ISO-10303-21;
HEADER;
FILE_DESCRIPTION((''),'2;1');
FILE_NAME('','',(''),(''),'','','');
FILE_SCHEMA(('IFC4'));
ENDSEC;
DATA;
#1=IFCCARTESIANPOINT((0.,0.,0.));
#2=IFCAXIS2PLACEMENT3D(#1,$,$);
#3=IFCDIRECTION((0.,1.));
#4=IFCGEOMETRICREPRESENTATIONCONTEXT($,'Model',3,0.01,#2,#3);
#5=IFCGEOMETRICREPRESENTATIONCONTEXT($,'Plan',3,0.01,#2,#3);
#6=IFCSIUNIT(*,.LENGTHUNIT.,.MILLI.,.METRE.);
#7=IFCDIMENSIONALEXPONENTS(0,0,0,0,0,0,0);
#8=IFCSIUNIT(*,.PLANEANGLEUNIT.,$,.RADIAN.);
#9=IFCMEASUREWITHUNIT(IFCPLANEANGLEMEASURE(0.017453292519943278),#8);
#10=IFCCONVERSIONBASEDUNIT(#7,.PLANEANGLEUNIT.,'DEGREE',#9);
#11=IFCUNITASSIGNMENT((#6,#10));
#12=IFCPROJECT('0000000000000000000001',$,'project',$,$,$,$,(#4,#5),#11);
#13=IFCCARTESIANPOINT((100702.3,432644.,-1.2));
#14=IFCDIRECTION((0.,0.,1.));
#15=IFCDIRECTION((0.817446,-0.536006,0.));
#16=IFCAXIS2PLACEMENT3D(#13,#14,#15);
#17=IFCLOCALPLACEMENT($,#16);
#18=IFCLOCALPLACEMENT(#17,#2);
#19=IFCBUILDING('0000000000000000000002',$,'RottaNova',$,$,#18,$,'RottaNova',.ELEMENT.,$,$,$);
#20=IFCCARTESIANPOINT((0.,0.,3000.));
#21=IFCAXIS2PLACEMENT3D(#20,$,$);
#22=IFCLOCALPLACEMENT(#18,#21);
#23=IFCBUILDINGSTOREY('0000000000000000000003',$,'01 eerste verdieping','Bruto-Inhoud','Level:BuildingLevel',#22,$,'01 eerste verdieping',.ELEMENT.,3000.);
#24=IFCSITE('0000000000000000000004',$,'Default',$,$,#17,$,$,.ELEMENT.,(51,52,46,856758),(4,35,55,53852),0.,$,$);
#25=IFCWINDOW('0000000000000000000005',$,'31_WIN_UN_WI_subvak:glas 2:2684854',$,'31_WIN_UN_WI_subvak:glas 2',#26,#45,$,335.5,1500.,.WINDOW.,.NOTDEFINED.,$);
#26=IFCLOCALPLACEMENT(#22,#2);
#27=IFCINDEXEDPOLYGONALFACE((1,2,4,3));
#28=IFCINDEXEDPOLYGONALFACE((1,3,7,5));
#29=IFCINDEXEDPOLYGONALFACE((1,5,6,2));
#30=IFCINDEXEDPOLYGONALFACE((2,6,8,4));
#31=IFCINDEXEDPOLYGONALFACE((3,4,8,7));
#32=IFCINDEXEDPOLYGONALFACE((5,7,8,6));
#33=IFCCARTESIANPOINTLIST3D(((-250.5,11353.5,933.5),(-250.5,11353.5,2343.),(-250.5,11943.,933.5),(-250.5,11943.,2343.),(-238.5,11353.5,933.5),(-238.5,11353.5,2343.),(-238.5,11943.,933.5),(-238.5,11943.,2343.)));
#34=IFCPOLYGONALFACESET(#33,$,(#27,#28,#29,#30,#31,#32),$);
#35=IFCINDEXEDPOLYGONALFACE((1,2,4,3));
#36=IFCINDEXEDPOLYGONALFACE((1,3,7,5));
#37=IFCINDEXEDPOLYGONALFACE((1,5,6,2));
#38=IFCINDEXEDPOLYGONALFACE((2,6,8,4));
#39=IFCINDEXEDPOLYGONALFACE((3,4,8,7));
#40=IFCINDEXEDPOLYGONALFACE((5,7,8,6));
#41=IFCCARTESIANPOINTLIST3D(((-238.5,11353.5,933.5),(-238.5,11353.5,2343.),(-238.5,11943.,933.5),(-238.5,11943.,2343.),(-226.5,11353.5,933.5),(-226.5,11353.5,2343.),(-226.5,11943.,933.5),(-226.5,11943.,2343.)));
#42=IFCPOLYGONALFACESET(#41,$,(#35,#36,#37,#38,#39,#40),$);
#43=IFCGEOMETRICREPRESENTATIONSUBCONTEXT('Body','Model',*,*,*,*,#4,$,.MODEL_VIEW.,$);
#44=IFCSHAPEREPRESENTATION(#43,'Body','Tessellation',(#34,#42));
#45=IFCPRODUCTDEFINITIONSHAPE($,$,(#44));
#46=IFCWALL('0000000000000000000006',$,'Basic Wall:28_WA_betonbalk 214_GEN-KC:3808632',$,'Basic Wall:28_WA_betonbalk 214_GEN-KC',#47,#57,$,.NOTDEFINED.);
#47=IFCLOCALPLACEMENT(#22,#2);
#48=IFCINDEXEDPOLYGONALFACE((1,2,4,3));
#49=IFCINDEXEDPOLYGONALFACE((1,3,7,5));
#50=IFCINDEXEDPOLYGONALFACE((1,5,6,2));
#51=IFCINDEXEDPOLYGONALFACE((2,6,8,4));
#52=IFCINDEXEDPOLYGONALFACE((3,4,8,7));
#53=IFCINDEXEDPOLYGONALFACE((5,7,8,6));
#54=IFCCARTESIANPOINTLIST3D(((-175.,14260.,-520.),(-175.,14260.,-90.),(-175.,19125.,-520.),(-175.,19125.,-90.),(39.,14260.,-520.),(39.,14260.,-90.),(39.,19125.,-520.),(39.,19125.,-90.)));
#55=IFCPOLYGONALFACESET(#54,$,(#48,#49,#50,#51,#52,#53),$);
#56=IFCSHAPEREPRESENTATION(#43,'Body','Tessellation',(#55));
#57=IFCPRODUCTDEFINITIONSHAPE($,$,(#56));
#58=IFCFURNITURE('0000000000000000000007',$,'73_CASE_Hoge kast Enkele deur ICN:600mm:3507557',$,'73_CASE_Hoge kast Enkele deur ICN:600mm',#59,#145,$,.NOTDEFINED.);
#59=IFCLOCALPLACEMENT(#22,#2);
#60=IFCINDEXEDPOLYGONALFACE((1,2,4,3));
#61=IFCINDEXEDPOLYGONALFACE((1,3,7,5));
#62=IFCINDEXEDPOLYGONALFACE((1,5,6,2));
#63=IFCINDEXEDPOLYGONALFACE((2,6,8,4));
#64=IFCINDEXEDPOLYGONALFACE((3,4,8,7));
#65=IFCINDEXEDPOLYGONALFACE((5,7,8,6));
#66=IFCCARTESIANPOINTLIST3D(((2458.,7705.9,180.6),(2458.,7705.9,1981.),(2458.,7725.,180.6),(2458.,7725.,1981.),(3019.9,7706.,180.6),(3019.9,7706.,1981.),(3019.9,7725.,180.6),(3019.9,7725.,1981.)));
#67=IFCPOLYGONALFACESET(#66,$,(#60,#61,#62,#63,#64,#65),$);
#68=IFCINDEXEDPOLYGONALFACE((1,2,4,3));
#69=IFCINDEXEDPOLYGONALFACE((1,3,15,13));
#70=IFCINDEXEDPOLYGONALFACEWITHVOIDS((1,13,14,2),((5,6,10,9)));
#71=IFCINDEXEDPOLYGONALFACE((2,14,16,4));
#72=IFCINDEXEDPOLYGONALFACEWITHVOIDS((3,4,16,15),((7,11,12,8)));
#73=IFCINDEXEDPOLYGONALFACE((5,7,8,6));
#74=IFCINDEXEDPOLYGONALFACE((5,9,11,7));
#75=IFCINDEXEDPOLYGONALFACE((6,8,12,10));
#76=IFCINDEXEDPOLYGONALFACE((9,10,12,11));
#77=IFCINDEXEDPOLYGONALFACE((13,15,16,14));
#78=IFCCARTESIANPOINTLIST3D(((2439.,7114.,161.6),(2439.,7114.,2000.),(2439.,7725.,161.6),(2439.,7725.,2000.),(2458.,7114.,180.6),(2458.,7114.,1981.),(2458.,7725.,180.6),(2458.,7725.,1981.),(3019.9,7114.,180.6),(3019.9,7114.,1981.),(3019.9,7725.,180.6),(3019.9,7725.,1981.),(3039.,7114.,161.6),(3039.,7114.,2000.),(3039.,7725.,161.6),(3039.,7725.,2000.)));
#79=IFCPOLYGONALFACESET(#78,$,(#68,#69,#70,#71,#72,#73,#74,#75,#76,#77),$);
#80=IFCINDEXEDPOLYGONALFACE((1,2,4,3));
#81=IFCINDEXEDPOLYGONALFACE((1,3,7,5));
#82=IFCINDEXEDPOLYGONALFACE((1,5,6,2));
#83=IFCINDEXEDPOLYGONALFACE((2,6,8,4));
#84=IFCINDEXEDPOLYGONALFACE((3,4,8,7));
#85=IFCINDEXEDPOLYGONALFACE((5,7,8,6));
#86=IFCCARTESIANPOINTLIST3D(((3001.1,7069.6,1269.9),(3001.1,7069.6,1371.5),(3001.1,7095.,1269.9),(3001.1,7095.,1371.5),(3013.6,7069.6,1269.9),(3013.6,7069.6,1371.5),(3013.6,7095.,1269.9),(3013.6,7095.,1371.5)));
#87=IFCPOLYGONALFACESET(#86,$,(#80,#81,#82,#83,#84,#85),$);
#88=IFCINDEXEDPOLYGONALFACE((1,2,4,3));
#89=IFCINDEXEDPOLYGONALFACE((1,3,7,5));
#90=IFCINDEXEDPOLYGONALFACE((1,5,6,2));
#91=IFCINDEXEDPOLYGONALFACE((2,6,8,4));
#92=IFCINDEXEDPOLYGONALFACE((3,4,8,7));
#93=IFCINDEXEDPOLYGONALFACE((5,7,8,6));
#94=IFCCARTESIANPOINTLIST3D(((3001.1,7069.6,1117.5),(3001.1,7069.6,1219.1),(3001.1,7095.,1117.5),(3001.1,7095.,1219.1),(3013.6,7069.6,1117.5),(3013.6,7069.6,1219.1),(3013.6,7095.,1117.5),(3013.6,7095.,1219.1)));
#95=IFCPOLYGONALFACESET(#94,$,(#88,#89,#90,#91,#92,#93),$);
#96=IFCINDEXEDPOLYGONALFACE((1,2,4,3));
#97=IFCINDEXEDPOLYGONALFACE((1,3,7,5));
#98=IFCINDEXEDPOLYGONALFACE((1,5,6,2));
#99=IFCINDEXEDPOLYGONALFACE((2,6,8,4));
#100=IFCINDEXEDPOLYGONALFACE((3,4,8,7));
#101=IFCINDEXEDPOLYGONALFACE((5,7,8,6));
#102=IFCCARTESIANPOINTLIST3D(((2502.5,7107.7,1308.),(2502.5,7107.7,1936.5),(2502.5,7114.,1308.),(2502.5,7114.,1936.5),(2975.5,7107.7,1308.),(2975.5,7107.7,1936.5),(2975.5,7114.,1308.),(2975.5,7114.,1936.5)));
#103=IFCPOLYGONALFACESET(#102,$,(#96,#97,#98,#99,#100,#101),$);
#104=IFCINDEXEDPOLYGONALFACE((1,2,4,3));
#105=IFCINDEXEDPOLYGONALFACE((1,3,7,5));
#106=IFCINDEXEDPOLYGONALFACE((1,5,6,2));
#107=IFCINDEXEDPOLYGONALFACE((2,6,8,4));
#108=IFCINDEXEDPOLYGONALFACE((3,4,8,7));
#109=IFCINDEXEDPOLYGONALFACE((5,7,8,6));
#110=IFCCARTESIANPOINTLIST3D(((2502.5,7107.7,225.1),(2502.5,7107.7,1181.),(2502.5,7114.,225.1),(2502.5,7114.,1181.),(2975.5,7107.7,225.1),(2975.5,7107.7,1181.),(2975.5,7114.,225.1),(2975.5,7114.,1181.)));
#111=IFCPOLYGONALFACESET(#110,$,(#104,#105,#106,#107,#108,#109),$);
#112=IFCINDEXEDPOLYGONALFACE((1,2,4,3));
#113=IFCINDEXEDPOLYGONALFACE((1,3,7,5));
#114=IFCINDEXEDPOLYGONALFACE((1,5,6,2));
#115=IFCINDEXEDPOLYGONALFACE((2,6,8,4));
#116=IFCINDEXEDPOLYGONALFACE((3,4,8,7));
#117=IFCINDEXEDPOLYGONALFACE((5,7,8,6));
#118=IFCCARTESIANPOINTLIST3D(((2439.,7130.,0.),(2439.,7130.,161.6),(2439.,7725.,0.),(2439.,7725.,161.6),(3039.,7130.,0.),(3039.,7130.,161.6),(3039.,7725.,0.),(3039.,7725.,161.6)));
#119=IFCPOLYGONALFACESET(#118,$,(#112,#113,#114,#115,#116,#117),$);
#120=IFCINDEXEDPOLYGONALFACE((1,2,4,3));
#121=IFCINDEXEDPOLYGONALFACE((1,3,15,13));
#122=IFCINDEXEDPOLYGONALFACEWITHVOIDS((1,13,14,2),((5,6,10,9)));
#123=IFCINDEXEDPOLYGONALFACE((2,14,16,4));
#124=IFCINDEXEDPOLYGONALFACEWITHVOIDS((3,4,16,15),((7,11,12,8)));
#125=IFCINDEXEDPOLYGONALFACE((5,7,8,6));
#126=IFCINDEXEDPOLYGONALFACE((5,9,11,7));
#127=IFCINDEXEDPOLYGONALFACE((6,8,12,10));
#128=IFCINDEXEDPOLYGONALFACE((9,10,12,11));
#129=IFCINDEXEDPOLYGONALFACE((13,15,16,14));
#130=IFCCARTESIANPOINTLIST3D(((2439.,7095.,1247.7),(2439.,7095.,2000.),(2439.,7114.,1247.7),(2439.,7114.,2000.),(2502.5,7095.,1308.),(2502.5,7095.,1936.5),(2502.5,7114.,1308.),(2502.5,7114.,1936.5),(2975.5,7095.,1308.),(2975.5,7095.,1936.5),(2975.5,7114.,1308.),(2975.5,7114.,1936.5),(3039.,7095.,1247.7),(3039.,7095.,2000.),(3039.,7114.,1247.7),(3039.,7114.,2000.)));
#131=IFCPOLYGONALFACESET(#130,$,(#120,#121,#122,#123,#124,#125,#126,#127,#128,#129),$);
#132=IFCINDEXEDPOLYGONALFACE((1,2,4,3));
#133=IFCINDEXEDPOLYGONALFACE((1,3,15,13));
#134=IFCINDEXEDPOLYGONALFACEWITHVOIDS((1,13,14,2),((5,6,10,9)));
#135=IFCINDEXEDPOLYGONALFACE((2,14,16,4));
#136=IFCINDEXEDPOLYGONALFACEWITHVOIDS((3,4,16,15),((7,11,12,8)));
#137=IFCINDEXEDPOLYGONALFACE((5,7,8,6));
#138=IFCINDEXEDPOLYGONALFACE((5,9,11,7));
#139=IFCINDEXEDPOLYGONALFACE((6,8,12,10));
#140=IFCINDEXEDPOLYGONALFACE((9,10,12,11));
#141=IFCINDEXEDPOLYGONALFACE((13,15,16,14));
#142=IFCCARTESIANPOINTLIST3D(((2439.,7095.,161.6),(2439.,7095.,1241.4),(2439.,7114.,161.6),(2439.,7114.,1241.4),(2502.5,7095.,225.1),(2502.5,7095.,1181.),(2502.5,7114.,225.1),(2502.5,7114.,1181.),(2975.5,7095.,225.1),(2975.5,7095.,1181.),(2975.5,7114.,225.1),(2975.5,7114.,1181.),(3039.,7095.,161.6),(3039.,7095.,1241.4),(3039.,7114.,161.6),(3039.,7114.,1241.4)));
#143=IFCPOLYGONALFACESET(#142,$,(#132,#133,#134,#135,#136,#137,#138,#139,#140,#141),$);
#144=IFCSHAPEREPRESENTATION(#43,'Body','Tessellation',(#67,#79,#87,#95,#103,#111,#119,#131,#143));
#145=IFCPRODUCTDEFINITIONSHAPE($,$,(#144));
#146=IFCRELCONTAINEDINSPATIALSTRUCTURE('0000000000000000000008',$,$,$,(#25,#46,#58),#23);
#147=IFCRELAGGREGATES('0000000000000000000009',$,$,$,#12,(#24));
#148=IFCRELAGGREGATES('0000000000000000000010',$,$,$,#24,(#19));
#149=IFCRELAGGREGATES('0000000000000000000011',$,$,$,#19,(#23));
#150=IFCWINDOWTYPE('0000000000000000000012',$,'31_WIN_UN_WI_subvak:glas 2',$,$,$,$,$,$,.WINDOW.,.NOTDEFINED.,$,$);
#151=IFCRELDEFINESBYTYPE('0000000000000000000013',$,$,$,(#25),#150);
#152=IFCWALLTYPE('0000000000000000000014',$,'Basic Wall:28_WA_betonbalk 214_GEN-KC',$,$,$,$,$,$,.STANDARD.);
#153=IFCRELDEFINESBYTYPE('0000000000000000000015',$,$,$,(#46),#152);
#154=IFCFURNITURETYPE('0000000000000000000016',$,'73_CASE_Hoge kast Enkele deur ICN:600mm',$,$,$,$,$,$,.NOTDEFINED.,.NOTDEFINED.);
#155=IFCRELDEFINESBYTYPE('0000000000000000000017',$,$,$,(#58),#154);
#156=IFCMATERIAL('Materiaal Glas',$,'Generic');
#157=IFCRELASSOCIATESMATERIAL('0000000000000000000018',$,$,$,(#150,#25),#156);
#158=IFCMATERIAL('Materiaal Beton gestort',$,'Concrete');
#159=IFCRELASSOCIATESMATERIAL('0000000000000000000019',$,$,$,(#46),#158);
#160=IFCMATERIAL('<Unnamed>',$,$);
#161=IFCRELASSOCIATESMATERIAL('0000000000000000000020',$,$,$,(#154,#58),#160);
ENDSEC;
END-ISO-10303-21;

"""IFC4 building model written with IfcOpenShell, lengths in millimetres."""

from ifc_helpers import new_model, entity, si_unit, converted_unit, direction, frame, origin, place, context, subcontext, project, spatial, indexed_curve, outline, extrude, source, transform, mapped, material, type_object, type_shapes, element, save


model = new_model("IFC4")

# Units and contexts
model_context = context("Model", 3, precision=0.01, world=origin(), true_north=direction((0.0, 1.0)))
plan_context = context("Plan", 3, precision=0.01, world=origin(), true_north=direction((0.0, 1.0)))
body_context = subcontext(model_context, "Body", "Model", "MODEL_VIEW")
ifc_project = project(units=[si_unit("LENGTHUNIT", "METRE", prefix="MILLI"), converted_unit("PLANEANGLEUNIT", "DEGREE", entity("IfcPlaneAngleMeasure", 0.017453292519943278), si_unit("PLANEANGLEUNIT", "RADIAN"), dimensions=[0, 0, 0, 0, 0, 0, 0])], contexts=[model_context, plan_context])

# Site, building, storey
site_placement = place(None, frame((100702.3, 432644.0, -1.2), z_axis=(0.0, 0.0, 1.0), x_axis=(0.817446, -0.536006, 0.0)))
site = spatial("IfcSite", under=ifc_project, at=site_placement, Name="Default", CompositionType="ELEMENT", RefLatitude=(51, 52, 46, 856758), RefLongitude=(4, 35, 55, 53852), RefElevation=0.0)
building_placement = place(site_placement, origin())
building = spatial("IfcBuilding", under=site, at=building_placement, Name="RottaNova", LongName="RottaNova", CompositionType="ELEMENT")
storey_placement = place(building_placement, frame((0.0, 0.0, 3000.0)))
storey = spatial("IfcBuildingStorey", under=building, at=storey_placement, Name="01 eerste verdieping", Description="Bruto-Inhoud", ObjectType="Level:BuildingLevel", LongName="01 eerste verdieping", CompositionType="ELEMENT", Elevation=3000.0)

# Shared definitions
ifc_material_1 = material(Name="Materiaal Glas", Category="Generic")

# Window
window_type = type_object("IfcWindowType", Name="31_WIN_UN_WI_subvak:glas 2", PartitioningType="NOTDEFINED", PredefinedType="WINDOW", material=ifc_material_1)
shared_shape_1 = source(origin(), body_context, "Body", "SweptSolid", [
    extrude(outline(indexed_curve([(-6.0, -294.7), (6.0, -294.7), (6.0, 294.7), (-6.0, 294.7), (-6.0, -294.7)], self_intersect=False)), frame((0.0, 6.0, 0.0), z_axis=(0.0, 0.0, 1.0), x_axis=(0.0, -1.0, 0.0)), (0.0, 0.0, 1.0), 1409.5),
    extrude(outline(indexed_curve([(-6.0, -294.8), (6.0, -294.8), (6.0, 294.8), (-6.0, 294.8), (-6.0, -294.8)], self_intersect=False)), frame((0.0, -6.0, 0.0), z_axis=(0.0, 0.0, 1.0), x_axis=(0.0, -1.0, 0.0)), (0.0, 0.0, 1.0), 1409.5),
])
type_shapes(window_type, [shared_shape_1])
window_1_placement = place(storey_placement, frame((-238.5, 11648.2, 933.5), z_axis=(0.0, 0.0, 1.0), x_axis=(0.0, 1.0, 0.0)))
element("IfcWindow", 1, at=window_1_placement, inside=storey, type_object=window_type, material=ifc_material_1, Name="31_WIN_UN_WI_subvak:glas 2:2684854", ObjectType="31_WIN_UN_WI_subvak:glas 2", OverallHeight=335.5, OverallWidth=1500.0, PartitioningType="NOTDEFINED", PredefinedType="WINDOW", context=body_context, shape_type="MappedRepresentation", body=[
    mapped(shared_shape_1, transform((0.0, 0.0, 0.0), scale=1.0)),
])

# Wall
ifc_material_2 = material(Name="Materiaal Beton gestort", Category="Concrete")
wall_type_1 = type_object("IfcWallType", Name="Basic Wall:28_WA_betonbalk 214_GEN-KC", PredefinedType="STANDARD")
wall_1_placement = place(storey_placement, frame((-68.0, 14260.0, -520.0), z_axis=(0.0, 0.0, 1.0), x_axis=(0.0, 1.0, 0.0)))
element("IfcWall", 2, at=wall_1_placement, inside=storey, type_object=wall_type_1, material=ifc_material_2, Name="Basic Wall:28_WA_betonbalk 214_GEN-KC:3808632", ObjectType="Basic Wall:28_WA_betonbalk 214_GEN-KC", PredefinedType="NOTDEFINED", context=body_context, shape_type="SweptSolid", body=[
    extrude(outline(indexed_curve([(4865.0, 107.0), (0.0, 107.0), (0.0, -107.0), (4865.0, -107.0), (4865.0, 107.0)], self_intersect=False)), origin(), (0.0, 0.0, 1.0), 430.0),
])

# Furniture
ifc_material_3 = material(Name="<Unnamed>")
furniture_type = type_object("IfcFurnitureType", Name="73_CASE_Hoge kast Enkele deur ICN:600mm", AssemblyPlace="NOTDEFINED", PredefinedType="NOTDEFINED", material=ifc_material_3)
shared_shape_2 = source(origin(), body_context, "Body", "SweptSolid", [
    extrude(outline(indexed_curve([(-9.5, -280.9), (9.5, -280.9), (9.5, 280.9), (-9.5, 280.9), (-9.5, -280.9)], self_intersect=False)), frame((18.7, -9.5, 180.6), z_axis=(0.0, 0.0, 1.0), x_axis=(0.0, 1.0, 0.0)), (0.0, 0.0, 1.0), 1800.3),
    extrude(outline(indexed_curve([(-300.0, -919.2), (300.0, -919.2), (300.0, 919.2), (-300.0, 919.2), (-300.0, -919.2)], self_intersect=False), holes=[indexed_curve([(-280.9, 900.2), (281.0, 900.2), (281.0, -900.2), (-280.9, -900.2), (-280.9, 900.2)], self_intersect=False)]), frame((18.7, -610.9, 1080.8), z_axis=(0.0, 1.0, 0.0), x_axis=(-1.0, 0.0, 0.0)), (0.0, 0.0, 1.0), 610.9),
    extrude(outline(indexed_curve([(-12.7, -6.3), (12.7, -6.3), (12.7, 6.3), (-12.7, 6.3), (-12.7, -6.3)], self_intersect=False)), frame((287.1, -642.7, 1269.9), z_axis=(0.0, 0.0, 1.0), x_axis=(0.0, 1.0, 0.0)), (0.0, 0.0, 1.0), 101.6),
    extrude(outline(indexed_curve([(-12.7, -6.3), (12.7, -6.3), (12.7, 6.3), (-12.7, 6.3), (-12.7, -6.3)], self_intersect=False)), frame((287.1, -642.7, 1117.5), z_axis=(0.0, 0.0, 1.0), x_axis=(0.0, 1.0, 0.0)), (0.0, 0.0, 1.0), 101.6),
    extrude(outline(indexed_curve([(-3.2, -236.5), (3.2, -236.5), (3.2, 236.5), (-3.2, 236.5), (-3.2, -236.5)], self_intersect=False)), frame((18.7, -614.1, 1308.0), z_axis=(0.0, 0.0, 1.0), x_axis=(0.0, 1.0, 0.0)), (0.0, 0.0, 1.0), 628.5),
    extrude(outline(indexed_curve([(-3.2, -236.5), (3.2, -236.5), (3.2, 236.5), (-3.2, 236.5), (-3.2, -236.5)], self_intersect=False)), frame((18.7, -614.1, 225.1), z_axis=(0.0, 0.0, 1.0), x_axis=(0.0, 1.0, 0.0)), (0.0, 0.0, 1.0), 956.0),
    extrude(outline(indexed_curve([(-300.0, -297.5), (300.0, -297.5), (300.0, 297.5), (-300.0, 297.5), (-300.0, -297.5)], self_intersect=False)), frame((18.7, -297.5, 0.0), z_axis=(0.0, 0.0, 1.0), x_axis=(-1.0, 0.0, 0.0)), (0.0, 0.0, 1.0), 161.6),
    extrude(outline(indexed_curve([(-376.1, -300.0), (376.1, -300.0), (376.1, 300.0), (-376.1, 300.0), (-376.1, -300.0)], self_intersect=False), holes=[indexed_curve([(-312.6, -236.5), (-312.6, 236.5), (315.8, 236.5), (315.8, -236.5), (-312.6, -236.5)], self_intersect=False)]), frame((18.7, -630.0, 1623.9), z_axis=(0.0, 1.0, 0.0), x_axis=(0.0, 0.0, -1.0)), (0.0, 0.0, 1.0), 19.1),
    extrude(outline(indexed_curve([(-300.0, -539.9), (300.0, -539.9), (300.0, 539.9), (-300.0, 539.9), (-300.0, -539.9)], self_intersect=False), holes=[indexed_curve([(-236.5, 479.6), (236.5, 479.6), (236.5, -476.4), (-236.5, -476.4), (-236.5, 479.6)], self_intersect=False)]), frame((18.7, -630.0, 701.5), z_axis=(0.0, 1.0, 0.0), x_axis=(-1.0, 0.0, 0.0)), (0.0, 0.0, 1.0), 19.1),
])
type_shapes(furniture_type, [shared_shape_2])
for number, where, name in (
    (3, (2720.3, 7725.0, 0.0), "73_CASE_Hoge kast Enkele deur ICN:600mm:3507557"),
):
    element("IfcFurniture", number, at=place(storey_placement, frame(where)), inside=storey, type_object=furniture_type, material=ifc_material_3, Name=name, ObjectType="73_CASE_Hoge kast Enkele deur ICN:600mm", PredefinedType="NOTDEFINED", context=body_context, shape_type="MappedRepresentation", body=[
        mapped(shared_shape_2, transform((0.0, 0.0, 0.0), scale=1.0)),
    ])

save(model, "model.ifc")
